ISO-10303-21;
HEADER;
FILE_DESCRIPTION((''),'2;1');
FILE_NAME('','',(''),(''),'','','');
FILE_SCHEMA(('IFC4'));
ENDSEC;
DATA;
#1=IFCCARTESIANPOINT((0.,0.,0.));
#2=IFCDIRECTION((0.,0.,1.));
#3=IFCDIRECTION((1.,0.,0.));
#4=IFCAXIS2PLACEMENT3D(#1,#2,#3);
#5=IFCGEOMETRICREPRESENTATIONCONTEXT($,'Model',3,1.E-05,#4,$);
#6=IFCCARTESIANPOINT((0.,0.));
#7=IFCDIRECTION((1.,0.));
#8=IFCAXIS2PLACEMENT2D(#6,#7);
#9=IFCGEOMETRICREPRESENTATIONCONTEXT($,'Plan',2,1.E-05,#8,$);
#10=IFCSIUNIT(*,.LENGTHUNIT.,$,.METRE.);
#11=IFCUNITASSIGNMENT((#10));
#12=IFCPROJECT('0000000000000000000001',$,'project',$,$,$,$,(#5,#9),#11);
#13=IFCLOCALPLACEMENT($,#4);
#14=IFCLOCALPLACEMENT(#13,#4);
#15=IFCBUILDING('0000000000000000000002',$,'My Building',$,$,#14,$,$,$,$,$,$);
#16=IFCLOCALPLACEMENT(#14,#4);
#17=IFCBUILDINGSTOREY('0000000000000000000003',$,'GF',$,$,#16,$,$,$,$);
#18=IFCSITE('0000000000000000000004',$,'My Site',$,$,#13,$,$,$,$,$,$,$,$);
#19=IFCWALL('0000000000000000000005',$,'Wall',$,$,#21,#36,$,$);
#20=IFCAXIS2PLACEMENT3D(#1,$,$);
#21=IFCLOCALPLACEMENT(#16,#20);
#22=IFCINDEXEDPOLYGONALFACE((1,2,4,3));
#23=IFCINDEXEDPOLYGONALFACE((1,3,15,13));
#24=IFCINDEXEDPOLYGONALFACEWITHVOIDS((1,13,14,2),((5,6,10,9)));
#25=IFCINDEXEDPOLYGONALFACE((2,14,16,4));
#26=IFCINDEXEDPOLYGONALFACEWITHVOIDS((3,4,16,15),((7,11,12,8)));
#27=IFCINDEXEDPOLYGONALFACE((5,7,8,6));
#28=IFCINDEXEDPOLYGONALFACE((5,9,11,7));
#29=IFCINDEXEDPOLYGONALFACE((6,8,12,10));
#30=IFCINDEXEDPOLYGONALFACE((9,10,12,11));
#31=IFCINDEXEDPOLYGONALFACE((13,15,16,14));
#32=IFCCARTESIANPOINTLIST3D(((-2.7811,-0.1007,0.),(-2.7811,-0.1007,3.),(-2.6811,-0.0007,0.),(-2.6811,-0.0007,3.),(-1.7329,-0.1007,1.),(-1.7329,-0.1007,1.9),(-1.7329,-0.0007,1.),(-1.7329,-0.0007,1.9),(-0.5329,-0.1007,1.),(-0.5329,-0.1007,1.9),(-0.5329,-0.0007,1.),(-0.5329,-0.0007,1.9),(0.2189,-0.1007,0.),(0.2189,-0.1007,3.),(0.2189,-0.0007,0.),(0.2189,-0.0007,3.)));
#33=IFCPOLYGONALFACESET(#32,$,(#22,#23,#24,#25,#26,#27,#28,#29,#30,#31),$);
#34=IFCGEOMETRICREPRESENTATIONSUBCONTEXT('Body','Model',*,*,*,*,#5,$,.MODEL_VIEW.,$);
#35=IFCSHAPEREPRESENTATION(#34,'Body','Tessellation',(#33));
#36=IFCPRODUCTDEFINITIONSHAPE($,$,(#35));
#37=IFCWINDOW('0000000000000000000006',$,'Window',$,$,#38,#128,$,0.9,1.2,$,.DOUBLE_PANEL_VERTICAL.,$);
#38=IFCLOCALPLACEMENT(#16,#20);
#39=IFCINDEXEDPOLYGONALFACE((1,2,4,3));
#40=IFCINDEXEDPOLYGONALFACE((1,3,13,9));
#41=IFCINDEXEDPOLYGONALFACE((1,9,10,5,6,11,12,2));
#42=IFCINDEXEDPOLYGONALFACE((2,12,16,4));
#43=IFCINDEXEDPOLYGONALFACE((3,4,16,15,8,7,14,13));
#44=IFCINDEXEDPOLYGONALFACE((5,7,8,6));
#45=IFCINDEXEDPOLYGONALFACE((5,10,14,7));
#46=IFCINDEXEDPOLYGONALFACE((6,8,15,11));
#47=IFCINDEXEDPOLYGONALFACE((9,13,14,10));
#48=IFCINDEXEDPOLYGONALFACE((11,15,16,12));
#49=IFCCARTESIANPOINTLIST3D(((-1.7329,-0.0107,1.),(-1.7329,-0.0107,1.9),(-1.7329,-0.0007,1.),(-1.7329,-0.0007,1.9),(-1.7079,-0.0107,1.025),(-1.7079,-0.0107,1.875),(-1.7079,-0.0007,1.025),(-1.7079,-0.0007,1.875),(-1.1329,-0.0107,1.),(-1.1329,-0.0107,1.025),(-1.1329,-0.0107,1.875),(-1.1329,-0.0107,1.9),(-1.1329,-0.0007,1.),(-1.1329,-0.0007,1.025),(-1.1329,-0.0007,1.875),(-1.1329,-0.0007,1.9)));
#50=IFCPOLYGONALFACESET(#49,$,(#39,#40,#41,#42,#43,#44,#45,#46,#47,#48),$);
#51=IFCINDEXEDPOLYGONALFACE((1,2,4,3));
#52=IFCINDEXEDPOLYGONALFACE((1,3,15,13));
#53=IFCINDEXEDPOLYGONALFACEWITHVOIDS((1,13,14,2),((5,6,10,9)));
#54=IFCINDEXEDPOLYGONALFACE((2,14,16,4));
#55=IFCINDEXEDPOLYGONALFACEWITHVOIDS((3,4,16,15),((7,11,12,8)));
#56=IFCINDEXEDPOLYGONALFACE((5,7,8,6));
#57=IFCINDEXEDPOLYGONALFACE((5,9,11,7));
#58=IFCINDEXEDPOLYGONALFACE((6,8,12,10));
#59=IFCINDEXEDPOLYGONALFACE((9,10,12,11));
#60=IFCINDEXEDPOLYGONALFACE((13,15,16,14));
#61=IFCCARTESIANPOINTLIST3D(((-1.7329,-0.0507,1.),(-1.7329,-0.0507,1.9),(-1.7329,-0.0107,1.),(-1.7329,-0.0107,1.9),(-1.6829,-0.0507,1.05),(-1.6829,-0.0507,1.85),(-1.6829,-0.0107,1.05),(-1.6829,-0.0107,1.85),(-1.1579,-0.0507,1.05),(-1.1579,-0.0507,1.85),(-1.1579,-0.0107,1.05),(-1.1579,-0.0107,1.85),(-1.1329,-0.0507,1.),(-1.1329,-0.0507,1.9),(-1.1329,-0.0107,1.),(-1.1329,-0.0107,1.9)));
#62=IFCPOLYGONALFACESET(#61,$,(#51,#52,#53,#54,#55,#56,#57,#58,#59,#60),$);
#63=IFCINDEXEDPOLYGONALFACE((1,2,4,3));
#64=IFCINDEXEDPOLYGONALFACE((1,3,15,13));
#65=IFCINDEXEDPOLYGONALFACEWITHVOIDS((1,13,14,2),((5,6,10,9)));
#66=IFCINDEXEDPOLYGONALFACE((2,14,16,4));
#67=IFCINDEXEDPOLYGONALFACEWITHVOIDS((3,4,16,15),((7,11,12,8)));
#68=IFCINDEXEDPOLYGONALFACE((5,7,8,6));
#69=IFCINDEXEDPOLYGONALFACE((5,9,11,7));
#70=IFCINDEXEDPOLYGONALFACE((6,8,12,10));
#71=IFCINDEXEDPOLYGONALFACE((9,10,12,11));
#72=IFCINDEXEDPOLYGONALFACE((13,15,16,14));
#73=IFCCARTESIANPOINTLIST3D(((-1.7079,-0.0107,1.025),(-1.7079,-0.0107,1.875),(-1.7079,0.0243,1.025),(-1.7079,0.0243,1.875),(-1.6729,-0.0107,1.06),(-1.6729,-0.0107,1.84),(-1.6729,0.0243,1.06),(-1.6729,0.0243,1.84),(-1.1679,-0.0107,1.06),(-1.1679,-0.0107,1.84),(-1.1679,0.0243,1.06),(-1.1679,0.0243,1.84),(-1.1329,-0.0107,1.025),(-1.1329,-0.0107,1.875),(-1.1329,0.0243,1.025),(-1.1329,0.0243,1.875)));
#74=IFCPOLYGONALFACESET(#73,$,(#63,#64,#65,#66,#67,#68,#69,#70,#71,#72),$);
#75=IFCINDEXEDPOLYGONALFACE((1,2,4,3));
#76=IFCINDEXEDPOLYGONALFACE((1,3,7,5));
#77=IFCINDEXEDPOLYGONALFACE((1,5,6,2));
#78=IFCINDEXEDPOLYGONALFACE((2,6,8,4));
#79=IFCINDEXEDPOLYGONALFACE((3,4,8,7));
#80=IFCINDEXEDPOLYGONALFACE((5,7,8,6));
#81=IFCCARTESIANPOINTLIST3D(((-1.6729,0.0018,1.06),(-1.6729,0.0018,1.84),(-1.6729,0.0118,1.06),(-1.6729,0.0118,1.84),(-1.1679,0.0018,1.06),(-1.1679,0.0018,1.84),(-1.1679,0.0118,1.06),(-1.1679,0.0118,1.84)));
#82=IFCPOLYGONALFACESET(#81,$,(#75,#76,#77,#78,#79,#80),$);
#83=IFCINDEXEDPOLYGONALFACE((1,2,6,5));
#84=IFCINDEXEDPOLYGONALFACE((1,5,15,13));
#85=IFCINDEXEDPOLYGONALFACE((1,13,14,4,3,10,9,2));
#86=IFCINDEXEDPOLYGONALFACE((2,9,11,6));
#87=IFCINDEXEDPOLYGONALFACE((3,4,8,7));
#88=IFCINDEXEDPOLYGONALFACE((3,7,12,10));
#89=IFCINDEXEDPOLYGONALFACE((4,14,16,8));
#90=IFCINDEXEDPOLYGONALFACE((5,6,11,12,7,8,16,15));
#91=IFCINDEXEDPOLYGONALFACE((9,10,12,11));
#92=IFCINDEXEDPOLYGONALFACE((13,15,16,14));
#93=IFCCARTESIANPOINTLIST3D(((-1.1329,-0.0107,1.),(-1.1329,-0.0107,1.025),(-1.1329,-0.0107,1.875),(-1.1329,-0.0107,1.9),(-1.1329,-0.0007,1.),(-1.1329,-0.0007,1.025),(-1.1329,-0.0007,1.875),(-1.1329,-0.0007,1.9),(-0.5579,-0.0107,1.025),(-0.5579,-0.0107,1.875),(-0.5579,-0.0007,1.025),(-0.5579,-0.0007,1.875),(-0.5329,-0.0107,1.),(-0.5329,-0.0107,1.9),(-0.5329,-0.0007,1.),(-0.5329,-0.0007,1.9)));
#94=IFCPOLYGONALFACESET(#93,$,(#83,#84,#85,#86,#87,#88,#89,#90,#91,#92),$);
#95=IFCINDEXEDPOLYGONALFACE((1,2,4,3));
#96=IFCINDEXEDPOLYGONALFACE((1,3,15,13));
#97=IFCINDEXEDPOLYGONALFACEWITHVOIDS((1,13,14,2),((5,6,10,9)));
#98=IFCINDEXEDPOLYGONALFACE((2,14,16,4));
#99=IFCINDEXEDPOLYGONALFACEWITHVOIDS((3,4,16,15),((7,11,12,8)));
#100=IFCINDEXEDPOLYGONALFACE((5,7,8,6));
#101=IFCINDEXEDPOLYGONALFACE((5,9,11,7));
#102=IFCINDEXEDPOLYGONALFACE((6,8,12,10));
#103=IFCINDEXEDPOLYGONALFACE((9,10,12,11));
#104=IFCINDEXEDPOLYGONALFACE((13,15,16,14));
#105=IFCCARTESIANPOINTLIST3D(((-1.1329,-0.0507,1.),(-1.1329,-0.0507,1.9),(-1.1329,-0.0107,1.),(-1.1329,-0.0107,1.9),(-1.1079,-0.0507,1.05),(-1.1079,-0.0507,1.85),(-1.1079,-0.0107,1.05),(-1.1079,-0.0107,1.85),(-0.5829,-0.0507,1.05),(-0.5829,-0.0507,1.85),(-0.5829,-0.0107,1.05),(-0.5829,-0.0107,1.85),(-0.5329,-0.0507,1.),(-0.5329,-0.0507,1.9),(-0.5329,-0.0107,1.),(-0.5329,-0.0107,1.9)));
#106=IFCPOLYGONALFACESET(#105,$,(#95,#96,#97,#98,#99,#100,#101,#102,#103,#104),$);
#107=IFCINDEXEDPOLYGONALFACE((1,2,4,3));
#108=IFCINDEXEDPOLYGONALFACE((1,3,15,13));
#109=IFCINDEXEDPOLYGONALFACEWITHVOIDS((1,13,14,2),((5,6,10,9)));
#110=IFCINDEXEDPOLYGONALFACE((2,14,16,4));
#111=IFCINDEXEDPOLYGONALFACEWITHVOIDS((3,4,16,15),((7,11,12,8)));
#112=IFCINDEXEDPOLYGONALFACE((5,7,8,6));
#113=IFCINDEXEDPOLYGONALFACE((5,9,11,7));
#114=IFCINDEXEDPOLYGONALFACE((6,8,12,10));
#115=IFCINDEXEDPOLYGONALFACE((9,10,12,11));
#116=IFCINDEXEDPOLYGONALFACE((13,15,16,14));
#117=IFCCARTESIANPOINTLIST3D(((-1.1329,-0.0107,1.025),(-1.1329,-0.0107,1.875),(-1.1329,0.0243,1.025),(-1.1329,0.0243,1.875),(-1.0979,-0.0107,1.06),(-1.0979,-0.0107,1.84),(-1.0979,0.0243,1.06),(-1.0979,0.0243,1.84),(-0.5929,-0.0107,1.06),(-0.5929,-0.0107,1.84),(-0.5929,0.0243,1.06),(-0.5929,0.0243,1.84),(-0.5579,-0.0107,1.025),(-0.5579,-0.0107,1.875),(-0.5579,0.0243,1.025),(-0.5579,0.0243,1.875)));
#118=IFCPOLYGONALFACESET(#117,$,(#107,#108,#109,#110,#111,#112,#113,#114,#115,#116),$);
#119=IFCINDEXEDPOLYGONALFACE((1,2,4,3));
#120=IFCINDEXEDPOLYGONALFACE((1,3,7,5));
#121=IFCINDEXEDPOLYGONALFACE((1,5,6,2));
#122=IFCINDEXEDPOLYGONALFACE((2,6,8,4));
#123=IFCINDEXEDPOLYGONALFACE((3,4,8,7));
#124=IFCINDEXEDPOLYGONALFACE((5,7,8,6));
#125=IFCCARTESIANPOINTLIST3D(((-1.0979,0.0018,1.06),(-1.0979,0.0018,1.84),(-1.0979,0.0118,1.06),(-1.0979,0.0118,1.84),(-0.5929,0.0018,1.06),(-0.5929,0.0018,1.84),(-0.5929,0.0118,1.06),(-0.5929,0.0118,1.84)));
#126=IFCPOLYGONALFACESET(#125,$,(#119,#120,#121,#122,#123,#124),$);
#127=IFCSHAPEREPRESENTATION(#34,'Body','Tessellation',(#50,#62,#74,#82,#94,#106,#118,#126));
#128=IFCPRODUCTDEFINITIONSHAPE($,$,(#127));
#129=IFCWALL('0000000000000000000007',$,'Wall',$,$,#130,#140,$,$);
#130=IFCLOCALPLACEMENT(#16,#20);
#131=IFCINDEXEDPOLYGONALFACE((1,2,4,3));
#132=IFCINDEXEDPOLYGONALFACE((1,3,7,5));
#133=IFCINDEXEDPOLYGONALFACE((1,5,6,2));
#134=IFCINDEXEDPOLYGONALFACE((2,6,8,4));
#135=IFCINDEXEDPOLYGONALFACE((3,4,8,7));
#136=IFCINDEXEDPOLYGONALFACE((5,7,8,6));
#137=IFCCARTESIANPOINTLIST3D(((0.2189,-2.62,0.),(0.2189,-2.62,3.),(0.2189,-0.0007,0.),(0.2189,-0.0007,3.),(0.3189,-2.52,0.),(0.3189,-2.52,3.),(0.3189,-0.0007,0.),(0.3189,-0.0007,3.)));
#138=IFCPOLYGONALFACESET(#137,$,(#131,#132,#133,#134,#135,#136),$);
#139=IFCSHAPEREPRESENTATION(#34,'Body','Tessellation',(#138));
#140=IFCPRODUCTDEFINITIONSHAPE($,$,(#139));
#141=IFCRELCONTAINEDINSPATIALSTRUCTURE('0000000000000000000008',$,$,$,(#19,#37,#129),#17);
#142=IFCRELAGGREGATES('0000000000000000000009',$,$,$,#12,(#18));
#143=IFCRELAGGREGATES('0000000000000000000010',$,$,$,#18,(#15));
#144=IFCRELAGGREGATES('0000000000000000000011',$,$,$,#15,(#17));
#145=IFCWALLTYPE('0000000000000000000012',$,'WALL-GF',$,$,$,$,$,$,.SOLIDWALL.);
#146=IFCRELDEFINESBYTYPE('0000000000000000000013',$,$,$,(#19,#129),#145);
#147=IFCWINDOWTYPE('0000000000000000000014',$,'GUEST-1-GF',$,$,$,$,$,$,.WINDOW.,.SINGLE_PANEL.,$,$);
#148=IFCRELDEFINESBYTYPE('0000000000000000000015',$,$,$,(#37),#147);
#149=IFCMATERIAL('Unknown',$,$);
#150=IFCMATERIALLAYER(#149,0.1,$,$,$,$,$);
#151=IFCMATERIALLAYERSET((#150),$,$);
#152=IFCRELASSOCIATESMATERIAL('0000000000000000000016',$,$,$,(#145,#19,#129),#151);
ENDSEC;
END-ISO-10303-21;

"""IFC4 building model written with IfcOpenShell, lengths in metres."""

from ifc_helpers import new_model, entity, si_unit, frame, origin_with_axes, origin_2d_with_axis, place, context, subcontext, project, spatial, line, indexed_curve, outline, extrude, shape, source, transform, mapped, material, layer, layer_set, layer_usage, type_object, type_shapes, element, fill, save


model = new_model("IFC4")

# Units and contexts
model_context = context("Model", 3, precision=1e-05, world=origin_with_axes())
plan_context = context("Plan", 2, precision=1e-05, world=origin_2d_with_axis())
body_context_1 = subcontext(model_context, "Body", "Model", "MODEL_VIEW")
body_context_2 = subcontext(plan_context, "Body", "Plan", "PLAN_VIEW")
ifc_project = project(units=[si_unit("LENGTHUNIT", "METRE")], contexts=[model_context, plan_context])

# Site, building, storey
site_placement = place(None, origin_with_axes())
site = spatial("IfcSite", under=ifc_project, at=site_placement, Name="My Site")
building_placement = place(site_placement, origin_with_axes())
building = spatial("IfcBuilding", under=site, at=building_placement, Name="My Building")
storey_placement = place(building_placement, origin_with_axes())
storey = spatial("IfcBuildingStorey", under=building, at=storey_placement, Name="GF")

# Shared definitions
ifc_material_1 = material(Name="Unknown")

# Shared definitions
ifc_layer_1 = layer(ifc_material_1, 0.1)
ifc_layer_set_1 = layer_set([ifc_layer_1])
wall_type = type_object("IfcWallType", Name="WALL-GF", PredefinedType="SOLIDWALL", material=ifc_layer_set_1)

# Wall, opening, window
ifc_layer_usage_1 = layer_usage(ifc_layer_set_1, "AXIS2", "POSITIVE", 0.0)
wall_1_placement = place(storey_placement, frame((-2.7811, -0.1007, 0.0), z_axis=(0.0, 0.0, 1.0), x_axis=(1.0, 0.0, 0.0)))
wall_1 = element("IfcWall", 1, at=wall_1_placement, inside=storey, type_object=wall_type, material=ifc_layer_usage_1, Name="Wall", context=body_context_1, shape_type="SweptSolid", body=[
    extrude(outline(indexed_curve([(0.0, 0.0), (0.1, 0.1), (3.0, 0.1), (3.0, 0.0)], segments=[line(1, 2, 3, 4, 1)])), origin_with_axes(), (0.0, 0.0, 1.0), 3.0),
])
shared_shape_1 = source(origin_with_axes(), body_context_1, "Body", "SweptSolid", [
    extrude(outline(indexed_curve([(0.0, 0.0), (1.2, 0.0), (1.2, 0.9), (0.0, 0.9)], segments=[line(1, 2, 3, 4, 1)])), frame((0.0, -0.6, 0.0), z_axis=(0.0, -1.0, 0.0), x_axis=(1.0, 0.0, 0.0)), (0.0, 0.0, -1.0), 1.2),
])
opening_1_placement = place(wall_1_placement, frame((1.0481, 0.0, 1.0), z_axis=(0.0, 0.0, 1.0), x_axis=(1.0, 0.0, 0.0)))
opening_1 = element("IfcOpeningElement", 2, at=opening_1_placement, cuts=wall_1, PredefinedType="OPENING", context=body_context_1, shape_type="MappedRepresentation", body=[
    mapped(shared_shape_1, transform((0.0, 0.0, 0.0), x_axis=(1.0, 0.0, 0.0), y_axis=(0.0, 1.0, 0.0), z_axis=(0.0, 0.0, 1.0), scale=1.0)),
])
window_type_1 = type_object("IfcWindowType", Name="GUEST-1-GF", PartitioningType="SINGLE_PANEL", PredefinedType="WINDOW")
shared_shape_2 = source(origin_with_axes(), body_context_1, "Body", "SweptSolid", [
    extrude(outline(indexed_curve([(0.6, 0.0), (0.0, 0.0), (0.0, 0.9), (0.6, 0.9), (0.6, 0.875), (0.025, 0.875), (0.025, 0.025), (0.6, 0.025)], segments=[line(1, 2, 3, 4, 5, 6, 7, 8, 1)])), frame((0.0, 0.09, 0.0), z_axis=(0.0, -1.0, 0.0), x_axis=(1.0, 0.0, 0.0)), (0.0, 0.0, -1.0), 0.01),
    extrude(outline(indexed_curve([(0.0, 0.0), (0.6, 0.0), (0.6, 0.9), (0.0, 0.9)], segments=[line(1, 2, 3, 4, 1)]), holes=[indexed_curve([(0.05, 0.05), (0.575, 0.05), (0.575, 0.85), (0.05, 0.85)], segments=[line(1, 2, 3, 4, 1)])]), frame((0.0, 0.05, 0.0), z_axis=(0.0, -1.0, 0.0), x_axis=(1.0, 0.0, 0.0)), (0.0, 0.0, -1.0), 0.04),
    extrude(outline(indexed_curve([(0.0, 0.0), (0.575, 0.0), (0.575, 0.85), (0.0, 0.85)], segments=[line(1, 2, 3, 4, 1)]), holes=[indexed_curve([(0.035, 0.035), (0.54, 0.035), (0.54, 0.815), (0.035, 0.815)], segments=[line(1, 2, 3, 4, 1)])]), frame((0.025, 0.09, 0.025), z_axis=(0.0, -1.0, 0.0), x_axis=(1.0, 0.0, 0.0)), (0.0, 0.0, -1.0), 0.035),
    extrude(outline(indexed_curve([(0.035, 0.035), (0.54, 0.035), (0.54, 0.815), (0.035, 0.815)], segments=[line(1, 2, 3, 4, 1)])), frame((0.025, 0.1025, 0.025), z_axis=(0.0, -1.0, 0.0), x_axis=(1.0, 0.0, 0.0)), (0.0, 0.0, -1.0), 0.01),
    extrude(outline(indexed_curve([(0.0, 0.9), (0.6, 0.9), (0.6, 0.0), (0.0, 0.0), (0.0, 0.025), (0.575, 0.025), (0.575, 0.875), (0.0, 0.875)], segments=[line(1, 2, 3, 4, 5, 6, 7, 8, 1)])), frame((0.6, 0.09, 0.0), z_axis=(0.0, -1.0, 0.0), x_axis=(1.0, 0.0, 0.0)), (0.0, 0.0, -1.0), 0.01),
    extrude(outline(indexed_curve([(0.0, 0.0), (0.6, 0.0), (0.6, 0.9), (0.0, 0.9)], segments=[line(1, 2, 3, 4, 1)]), holes=[indexed_curve([(0.025, 0.05), (0.55, 0.05), (0.55, 0.85), (0.025, 0.85)], segments=[line(1, 2, 3, 4, 1)])]), frame((0.6, 0.05, 0.0), z_axis=(0.0, -1.0, 0.0), x_axis=(1.0, 0.0, 0.0)), (0.0, 0.0, -1.0), 0.04),
    extrude(outline(indexed_curve([(0.0, 0.0), (0.575, 0.0), (0.575, 0.85), (0.0, 0.85)], segments=[line(1, 2, 3, 4, 1)]), holes=[indexed_curve([(0.035, 0.035), (0.54, 0.035), (0.54, 0.815), (0.035, 0.815)], segments=[line(1, 2, 3, 4, 1)])]), frame((0.6, 0.09, 0.025), z_axis=(0.0, -1.0, 0.0), x_axis=(1.0, 0.0, 0.0)), (0.0, 0.0, -1.0), 0.035),
    extrude(outline(indexed_curve([(0.035, 0.035), (0.54, 0.035), (0.54, 0.815), (0.035, 0.815)], segments=[line(1, 2, 3, 4, 1)])), frame((0.6, 0.1025, 0.025), z_axis=(0.0, -1.0, 0.0), x_axis=(1.0, 0.0, 0.0)), (0.0, 0.0, -1.0), 0.01),
])
shared_shape_3 = source(origin_with_axes(), body_context_2, "Body", "Curve2D", [
    entity("IfcIndexedPolyCurve", entity("IfcCartesianPointList2D", [[0.05, 0.05], [0.575, 0.05]])),
    entity("IfcIndexedPolyCurve", entity("IfcCartesianPointList2D", [[0.0, 0.1], [0.025, 0.1], [0.025, 0.09], [0.05, 0.09], [0.05, 0.05], [0.0, 0.05]]), [entity("IfcLineIndex", [1, 2, 3, 4, 5, 6, 1])]),
    entity("IfcIndexedPolyCurve", entity("IfcCartesianPointList2D", [[0.6, 0.1], [0.6, 0.1], [0.6, 0.09], [0.575, 0.09], [0.575, 0.05], [0.6, 0.05]])),
    entity("IfcIndexedPolyCurve", entity("IfcCartesianPointList2D", [[0.025, 0.09], [0.06, 0.09], [0.06, 0.125], [0.025, 0.125]]), [entity("IfcLineIndex", [1, 2, 3, 4, 1])]),
    entity("IfcIndexedPolyCurve", entity("IfcCartesianPointList2D", [[0.6, 0.09], [0.565, 0.09], [0.565, 0.125], [0.6, 0.125]]), [entity("IfcLineIndex", [1, 2, 3, 4, 1])]),
    entity("IfcIndexedPolyCurve", entity("IfcCartesianPointList2D", [[0.06, 0.09], [0.565, 0.09]])),
    entity("IfcIndexedPolyCurve", entity("IfcCartesianPointList2D", [[0.06, 0.125], [0.565, 0.125]])),
    entity("IfcIndexedPolyCurve", entity("IfcCartesianPointList2D", [[0.06, 0.1075], [0.565, 0.1075]])),
    entity("IfcIndexedPolyCurve", entity("IfcCartesianPointList2D", [[0.625, 0.05], [1.15, 0.05]])),
    entity("IfcIndexedPolyCurve", entity("IfcCartesianPointList2D", [[0.6, 0.1], [0.6, 0.1], [0.6, 0.09], [0.625, 0.09], [0.625, 0.05], [0.6, 0.05]])),
    entity("IfcIndexedPolyCurve", entity("IfcCartesianPointList2D", [[1.2, 0.1], [1.175, 0.1], [1.175, 0.09], [1.15, 0.09], [1.15, 0.05], [1.2, 0.05]]), [entity("IfcLineIndex", [1, 2, 3, 4, 5, 6, 1])]),
    entity("IfcIndexedPolyCurve", entity("IfcCartesianPointList2D", [[0.6, 0.09], [0.635, 0.09], [0.635, 0.125], [0.6, 0.125]]), [entity("IfcLineIndex", [1, 2, 3, 4, 1])]),
    entity("IfcIndexedPolyCurve", entity("IfcCartesianPointList2D", [[1.175, 0.09], [1.14, 0.09], [1.14, 0.125], [1.175, 0.125]]), [entity("IfcLineIndex", [1, 2, 3, 4, 1])]),
    entity("IfcIndexedPolyCurve", entity("IfcCartesianPointList2D", [[0.635, 0.09], [1.14, 0.09]])),
    entity("IfcIndexedPolyCurve", entity("IfcCartesianPointList2D", [[0.635, 0.125], [1.14, 0.125]])),
    entity("IfcIndexedPolyCurve", entity("IfcCartesianPointList2D", [[0.635, 0.1075], [1.14, 0.1075]])),
])
type_shapes(window_type_1, [shared_shape_2, shared_shape_3])
window_1_placement = place(opening_1_placement, origin_with_axes())
window_1 = element("IfcWindow", 3, at=window_1_placement, inside=storey, type_object=window_type_1, Name="Window", OverallHeight=0.9, OverallWidth=1.2, PartitioningType="DOUBLE_PANEL_VERTICAL", shapes=[
    shape(body_context_1, "Body", "MappedRepresentation", [mapped(shared_shape_2, transform((0.0, 0.0, 0.0), x_axis=(1.0, 0.0, 0.0), y_axis=(0.0, 1.0, 0.0), z_axis=(0.0, 0.0, 1.0), scale=1.0))]),
    shape(body_context_2, "Body", "MappedRepresentation", [mapped(shared_shape_3, transform((0.0, 0.0, 0.0), x_axis=(1.0, 0.0, 0.0), y_axis=(0.0, 1.0, 0.0), z_axis=(0.0, 0.0, 1.0), scale=1.0))]),
])
fill(opening_1, window_1)

# Wall
ifc_layer_usage_2 = layer_usage(ifc_layer_set_1, "AXIS2", "POSITIVE", 0.0)
wall_2_placement = place(storey_placement, frame((0.2189, -0.0007, 0.0), z_axis=(0.0, 0.0, 1.0), x_axis=(0.0, -1.0, 0.0)))
element("IfcWall", 4, at=wall_2_placement, inside=storey, type_object=wall_type, material=ifc_layer_usage_2, Name="Wall", context=body_context_1, shape_type="SweptSolid", body=[
    extrude(outline(indexed_curve([(0.0, 0.0), (0.0, 0.1), (2.5193, 0.1), (2.6193, 0.0)], segments=[line(1, 2, 3, 4, 1)])), origin_with_axes(), (0.0, 0.0, 1.0), 3.0),
])

save(model, "model.ifc")
